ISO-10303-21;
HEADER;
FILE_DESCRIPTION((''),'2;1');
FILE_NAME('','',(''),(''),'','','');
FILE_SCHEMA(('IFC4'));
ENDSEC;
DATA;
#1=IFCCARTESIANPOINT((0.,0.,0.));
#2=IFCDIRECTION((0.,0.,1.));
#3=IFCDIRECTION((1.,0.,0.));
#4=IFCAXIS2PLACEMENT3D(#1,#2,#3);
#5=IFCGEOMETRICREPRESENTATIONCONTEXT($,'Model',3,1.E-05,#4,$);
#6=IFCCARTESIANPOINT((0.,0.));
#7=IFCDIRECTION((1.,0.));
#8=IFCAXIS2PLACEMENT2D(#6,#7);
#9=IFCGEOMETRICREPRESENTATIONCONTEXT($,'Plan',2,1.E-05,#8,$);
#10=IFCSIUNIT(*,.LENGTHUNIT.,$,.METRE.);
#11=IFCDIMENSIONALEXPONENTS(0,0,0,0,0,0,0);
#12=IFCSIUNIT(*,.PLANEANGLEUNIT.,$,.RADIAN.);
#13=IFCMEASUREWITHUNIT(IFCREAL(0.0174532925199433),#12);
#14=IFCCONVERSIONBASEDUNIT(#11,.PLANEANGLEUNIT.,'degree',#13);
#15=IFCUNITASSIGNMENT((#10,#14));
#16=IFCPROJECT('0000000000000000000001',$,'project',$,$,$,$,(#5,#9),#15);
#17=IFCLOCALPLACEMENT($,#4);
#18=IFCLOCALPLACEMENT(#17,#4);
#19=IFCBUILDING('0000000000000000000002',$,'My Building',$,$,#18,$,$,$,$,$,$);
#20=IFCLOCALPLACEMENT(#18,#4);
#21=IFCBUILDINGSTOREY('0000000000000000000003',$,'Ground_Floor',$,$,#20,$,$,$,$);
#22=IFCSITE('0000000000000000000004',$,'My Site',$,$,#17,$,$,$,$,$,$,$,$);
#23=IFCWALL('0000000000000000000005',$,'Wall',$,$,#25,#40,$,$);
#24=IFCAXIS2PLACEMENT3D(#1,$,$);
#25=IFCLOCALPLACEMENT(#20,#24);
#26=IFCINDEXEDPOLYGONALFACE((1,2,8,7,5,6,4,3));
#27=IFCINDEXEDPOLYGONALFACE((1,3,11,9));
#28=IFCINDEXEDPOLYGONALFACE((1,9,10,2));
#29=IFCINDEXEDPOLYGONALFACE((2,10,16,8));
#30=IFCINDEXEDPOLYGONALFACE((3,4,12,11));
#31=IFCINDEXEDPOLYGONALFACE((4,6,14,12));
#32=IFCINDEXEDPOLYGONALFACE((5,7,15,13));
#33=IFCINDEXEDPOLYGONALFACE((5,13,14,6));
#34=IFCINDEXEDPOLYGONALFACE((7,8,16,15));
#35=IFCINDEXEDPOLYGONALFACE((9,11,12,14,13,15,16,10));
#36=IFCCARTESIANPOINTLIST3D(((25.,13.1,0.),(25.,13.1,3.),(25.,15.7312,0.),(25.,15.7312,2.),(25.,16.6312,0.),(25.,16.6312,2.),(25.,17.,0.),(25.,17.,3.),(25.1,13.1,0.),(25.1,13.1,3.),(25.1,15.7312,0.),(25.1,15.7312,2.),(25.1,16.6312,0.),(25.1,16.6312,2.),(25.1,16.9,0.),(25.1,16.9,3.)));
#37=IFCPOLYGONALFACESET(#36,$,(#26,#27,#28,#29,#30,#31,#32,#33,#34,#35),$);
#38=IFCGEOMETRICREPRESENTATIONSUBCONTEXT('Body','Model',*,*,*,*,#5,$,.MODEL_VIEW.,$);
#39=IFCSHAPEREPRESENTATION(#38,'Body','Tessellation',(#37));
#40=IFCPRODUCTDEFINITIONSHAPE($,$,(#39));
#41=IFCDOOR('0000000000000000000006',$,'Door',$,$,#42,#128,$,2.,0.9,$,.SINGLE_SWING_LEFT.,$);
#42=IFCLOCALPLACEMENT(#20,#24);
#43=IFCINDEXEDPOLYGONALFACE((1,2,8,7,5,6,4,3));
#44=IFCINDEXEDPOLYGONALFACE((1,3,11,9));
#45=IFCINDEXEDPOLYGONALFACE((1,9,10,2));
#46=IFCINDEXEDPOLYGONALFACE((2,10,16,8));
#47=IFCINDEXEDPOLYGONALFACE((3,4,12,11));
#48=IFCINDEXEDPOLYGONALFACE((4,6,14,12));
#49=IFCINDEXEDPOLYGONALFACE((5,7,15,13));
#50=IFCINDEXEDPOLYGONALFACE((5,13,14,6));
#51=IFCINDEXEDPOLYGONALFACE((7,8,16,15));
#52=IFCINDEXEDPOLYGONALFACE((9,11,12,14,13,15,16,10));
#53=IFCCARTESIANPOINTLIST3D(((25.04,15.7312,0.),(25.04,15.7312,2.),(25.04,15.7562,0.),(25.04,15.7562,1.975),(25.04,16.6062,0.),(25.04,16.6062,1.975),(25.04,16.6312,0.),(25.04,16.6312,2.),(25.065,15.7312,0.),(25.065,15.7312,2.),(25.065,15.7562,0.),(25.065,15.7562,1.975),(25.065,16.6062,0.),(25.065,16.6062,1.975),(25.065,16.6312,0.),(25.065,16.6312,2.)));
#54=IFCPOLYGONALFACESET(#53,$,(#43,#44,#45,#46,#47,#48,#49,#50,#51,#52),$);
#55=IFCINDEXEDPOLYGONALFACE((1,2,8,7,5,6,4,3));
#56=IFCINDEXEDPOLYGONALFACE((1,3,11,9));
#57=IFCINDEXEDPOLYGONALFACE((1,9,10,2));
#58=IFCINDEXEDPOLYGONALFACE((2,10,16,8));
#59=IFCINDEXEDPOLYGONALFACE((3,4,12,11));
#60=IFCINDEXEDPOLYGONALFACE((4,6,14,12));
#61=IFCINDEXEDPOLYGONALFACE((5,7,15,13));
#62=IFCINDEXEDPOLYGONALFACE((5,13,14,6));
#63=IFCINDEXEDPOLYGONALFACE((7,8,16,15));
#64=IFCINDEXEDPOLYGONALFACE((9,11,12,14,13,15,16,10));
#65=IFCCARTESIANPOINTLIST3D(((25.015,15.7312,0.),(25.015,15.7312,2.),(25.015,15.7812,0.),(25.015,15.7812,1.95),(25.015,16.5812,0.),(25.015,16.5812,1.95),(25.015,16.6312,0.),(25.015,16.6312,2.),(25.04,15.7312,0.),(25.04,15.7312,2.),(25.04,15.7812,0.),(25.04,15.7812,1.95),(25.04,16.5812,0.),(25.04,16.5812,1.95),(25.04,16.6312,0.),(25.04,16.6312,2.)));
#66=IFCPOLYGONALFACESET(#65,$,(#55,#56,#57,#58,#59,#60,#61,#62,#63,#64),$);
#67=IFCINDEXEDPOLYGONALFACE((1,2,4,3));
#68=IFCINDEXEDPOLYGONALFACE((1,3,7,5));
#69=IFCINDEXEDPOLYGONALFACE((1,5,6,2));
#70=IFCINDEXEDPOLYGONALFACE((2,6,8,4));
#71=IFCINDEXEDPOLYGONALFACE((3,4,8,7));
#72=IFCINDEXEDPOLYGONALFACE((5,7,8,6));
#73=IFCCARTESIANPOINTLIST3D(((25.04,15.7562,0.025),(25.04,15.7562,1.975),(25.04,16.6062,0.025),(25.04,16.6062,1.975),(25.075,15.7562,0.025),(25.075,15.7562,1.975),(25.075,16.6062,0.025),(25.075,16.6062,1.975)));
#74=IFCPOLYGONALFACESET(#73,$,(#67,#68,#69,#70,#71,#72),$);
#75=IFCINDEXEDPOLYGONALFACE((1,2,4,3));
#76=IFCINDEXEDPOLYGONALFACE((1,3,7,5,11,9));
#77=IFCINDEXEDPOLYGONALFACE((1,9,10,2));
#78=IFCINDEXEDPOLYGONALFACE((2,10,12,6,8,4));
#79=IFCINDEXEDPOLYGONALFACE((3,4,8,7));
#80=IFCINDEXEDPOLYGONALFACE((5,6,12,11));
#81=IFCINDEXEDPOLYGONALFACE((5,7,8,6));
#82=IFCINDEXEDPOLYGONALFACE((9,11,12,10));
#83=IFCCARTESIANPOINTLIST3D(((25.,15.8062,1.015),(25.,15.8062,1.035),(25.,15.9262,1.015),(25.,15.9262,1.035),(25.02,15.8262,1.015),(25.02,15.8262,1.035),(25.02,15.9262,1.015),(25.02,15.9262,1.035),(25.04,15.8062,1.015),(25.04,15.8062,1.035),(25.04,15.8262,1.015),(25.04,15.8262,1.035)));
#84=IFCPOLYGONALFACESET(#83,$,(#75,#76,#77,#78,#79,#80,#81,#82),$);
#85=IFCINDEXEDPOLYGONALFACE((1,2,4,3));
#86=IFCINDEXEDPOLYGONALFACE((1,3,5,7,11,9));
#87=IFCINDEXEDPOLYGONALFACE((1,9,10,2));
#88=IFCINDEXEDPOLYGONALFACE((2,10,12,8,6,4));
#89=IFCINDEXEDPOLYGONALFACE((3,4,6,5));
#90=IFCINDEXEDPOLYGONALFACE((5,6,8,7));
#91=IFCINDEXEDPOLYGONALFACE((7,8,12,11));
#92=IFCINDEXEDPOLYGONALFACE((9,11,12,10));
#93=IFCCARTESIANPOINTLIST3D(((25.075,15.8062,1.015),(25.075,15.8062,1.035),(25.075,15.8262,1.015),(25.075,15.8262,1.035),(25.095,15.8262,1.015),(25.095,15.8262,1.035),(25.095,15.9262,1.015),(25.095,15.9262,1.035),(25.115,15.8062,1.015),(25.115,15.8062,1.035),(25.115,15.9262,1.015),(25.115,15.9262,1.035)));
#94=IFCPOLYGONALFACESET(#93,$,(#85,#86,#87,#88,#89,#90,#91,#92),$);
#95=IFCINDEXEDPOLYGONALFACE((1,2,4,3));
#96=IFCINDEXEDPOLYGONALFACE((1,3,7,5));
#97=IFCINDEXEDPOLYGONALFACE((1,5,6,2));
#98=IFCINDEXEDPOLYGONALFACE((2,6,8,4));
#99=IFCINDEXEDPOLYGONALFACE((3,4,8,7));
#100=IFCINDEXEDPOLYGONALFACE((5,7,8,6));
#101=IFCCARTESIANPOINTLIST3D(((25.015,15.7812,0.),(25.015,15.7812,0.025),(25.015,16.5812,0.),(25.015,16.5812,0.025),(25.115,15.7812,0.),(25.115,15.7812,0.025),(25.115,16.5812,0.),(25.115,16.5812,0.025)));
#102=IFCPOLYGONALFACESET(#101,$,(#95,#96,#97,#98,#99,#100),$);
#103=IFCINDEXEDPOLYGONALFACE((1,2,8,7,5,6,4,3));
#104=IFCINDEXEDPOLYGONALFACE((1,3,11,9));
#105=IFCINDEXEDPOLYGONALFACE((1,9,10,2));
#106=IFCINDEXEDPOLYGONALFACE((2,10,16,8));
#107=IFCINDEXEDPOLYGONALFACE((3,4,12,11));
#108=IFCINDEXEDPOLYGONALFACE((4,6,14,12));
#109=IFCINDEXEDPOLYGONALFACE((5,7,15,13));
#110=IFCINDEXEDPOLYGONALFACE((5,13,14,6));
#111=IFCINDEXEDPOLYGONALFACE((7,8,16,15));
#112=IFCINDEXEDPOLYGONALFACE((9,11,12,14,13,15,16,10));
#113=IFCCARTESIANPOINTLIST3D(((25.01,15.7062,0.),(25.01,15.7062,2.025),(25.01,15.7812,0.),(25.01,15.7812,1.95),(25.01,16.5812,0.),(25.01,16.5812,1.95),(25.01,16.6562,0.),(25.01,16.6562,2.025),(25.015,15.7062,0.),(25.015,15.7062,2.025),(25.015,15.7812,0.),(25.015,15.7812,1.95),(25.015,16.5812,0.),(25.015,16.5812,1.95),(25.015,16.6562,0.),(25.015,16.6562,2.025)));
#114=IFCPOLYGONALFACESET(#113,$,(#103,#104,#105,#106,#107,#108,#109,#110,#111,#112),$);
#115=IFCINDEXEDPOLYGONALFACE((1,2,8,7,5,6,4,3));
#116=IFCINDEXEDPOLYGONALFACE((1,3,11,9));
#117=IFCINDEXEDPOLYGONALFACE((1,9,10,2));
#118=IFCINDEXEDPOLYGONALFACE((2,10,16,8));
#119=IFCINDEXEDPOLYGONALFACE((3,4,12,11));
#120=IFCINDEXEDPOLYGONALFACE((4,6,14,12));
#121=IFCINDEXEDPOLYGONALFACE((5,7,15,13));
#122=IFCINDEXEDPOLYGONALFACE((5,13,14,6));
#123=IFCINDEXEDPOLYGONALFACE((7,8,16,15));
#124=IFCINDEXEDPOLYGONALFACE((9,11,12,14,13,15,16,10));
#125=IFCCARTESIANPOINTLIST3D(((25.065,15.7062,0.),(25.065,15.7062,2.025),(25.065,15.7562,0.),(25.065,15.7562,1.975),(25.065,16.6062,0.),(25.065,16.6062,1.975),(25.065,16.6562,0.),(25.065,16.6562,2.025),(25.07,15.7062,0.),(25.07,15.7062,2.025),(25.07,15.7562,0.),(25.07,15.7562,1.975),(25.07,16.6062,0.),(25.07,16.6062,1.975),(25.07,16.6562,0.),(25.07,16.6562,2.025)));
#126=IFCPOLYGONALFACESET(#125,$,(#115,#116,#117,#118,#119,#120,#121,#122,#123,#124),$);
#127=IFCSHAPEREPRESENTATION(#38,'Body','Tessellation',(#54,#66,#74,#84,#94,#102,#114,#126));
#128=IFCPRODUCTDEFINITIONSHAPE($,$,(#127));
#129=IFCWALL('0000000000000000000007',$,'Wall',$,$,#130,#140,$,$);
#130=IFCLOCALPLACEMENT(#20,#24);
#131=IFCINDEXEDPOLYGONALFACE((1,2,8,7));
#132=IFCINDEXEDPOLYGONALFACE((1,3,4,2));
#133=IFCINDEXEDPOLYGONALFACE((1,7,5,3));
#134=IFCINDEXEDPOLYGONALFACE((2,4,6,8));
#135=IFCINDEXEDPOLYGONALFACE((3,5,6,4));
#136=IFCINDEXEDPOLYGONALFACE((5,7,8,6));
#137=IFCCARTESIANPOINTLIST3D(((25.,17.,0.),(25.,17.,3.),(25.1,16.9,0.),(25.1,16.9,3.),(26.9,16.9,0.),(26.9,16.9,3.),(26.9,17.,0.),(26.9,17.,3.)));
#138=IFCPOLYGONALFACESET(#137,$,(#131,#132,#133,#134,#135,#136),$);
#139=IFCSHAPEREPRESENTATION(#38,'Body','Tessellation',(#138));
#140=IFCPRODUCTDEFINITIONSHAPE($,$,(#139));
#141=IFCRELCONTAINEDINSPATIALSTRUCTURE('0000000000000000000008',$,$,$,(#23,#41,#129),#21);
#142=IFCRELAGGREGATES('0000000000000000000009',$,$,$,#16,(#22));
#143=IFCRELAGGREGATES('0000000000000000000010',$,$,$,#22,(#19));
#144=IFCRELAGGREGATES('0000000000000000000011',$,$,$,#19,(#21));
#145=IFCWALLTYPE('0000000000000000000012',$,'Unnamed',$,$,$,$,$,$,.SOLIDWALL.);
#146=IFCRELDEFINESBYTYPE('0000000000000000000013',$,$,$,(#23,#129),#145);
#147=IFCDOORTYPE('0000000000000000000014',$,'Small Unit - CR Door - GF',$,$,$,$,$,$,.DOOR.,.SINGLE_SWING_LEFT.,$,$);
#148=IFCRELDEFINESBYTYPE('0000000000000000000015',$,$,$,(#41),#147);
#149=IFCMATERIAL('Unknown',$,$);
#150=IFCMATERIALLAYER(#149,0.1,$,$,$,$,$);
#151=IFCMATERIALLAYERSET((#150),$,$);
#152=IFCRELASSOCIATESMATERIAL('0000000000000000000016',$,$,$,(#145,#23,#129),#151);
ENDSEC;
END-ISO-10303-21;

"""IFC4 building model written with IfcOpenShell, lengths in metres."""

from ifc_helpers import new_model, entity, si_unit, converted_unit, frame, origin_with_axes, origin_2d_with_axis, place, context, subcontext, project, spatial, line, indexed_curve, outline, extrude, shape, source, transform, mapped, material, layer, layer_set, layer_usage, type_object, type_shapes, element, fill, save


model = new_model("IFC4")

# Units and contexts
model_context = context("Model", 3, precision=1e-05, world=origin_with_axes())
plan_context = context("Plan", 2, precision=1e-05, world=origin_2d_with_axis())
body_context_1 = subcontext(model_context, "Body", "Model", "MODEL_VIEW")
body_context_2 = subcontext(plan_context, "Body", "Plan", "PLAN_VIEW")
ifc_project = project(units=[si_unit("LENGTHUNIT", "METRE"), converted_unit("PLANEANGLEUNIT", "degree", entity("IfcReal", 0.0174532925199433), si_unit("PLANEANGLEUNIT", "RADIAN"), dimensions=[0, 0, 0, 0, 0, 0, 0])], contexts=[model_context, plan_context])

# Site, building, storey
site_placement = place(None, origin_with_axes())
site = spatial("IfcSite", under=ifc_project, at=site_placement, Name="My Site")
building_placement = place(site_placement, origin_with_axes())
building = spatial("IfcBuilding", under=site, at=building_placement, Name="My Building")
storey_placement = place(building_placement, origin_with_axes())
storey = spatial("IfcBuildingStorey", under=building, at=storey_placement, Name="Ground_Floor")

# Shared definitions
ifc_material = material(Name="Unknown")
ifc_layer = layer(ifc_material, 0.1)
ifc_layer_set = layer_set([ifc_layer])
wall_type = type_object("IfcWallType", Name="Unnamed", PredefinedType="SOLIDWALL", material=ifc_layer_set)

# Shared definitions
shared_shape_1 = source(origin_with_axes(), body_context_1, "Body", "SweptSolid", [
    extrude(outline(indexed_curve([(0.0, 0.0), (0.9, 0.0), (0.9, 2.0), (0.0, 2.0)], segments=[line(1, 2, 3, 4, 1)])), frame((0.0, -0.6, 0.0), z_axis=(0.0, -1.0, 0.0), x_axis=(1.0, 0.0, 0.0)), (0.0, 0.0, -1.0), 1.2),
])
door_type_1 = type_object("IfcDoorType", Name="Small Unit - CR Door - GF", OperationType="SINGLE_SWING_LEFT", PredefinedType="DOOR")
shared_shape_2 = source(origin_with_axes(), body_context_1, "Body", "SweptSolid", [
    extrude(outline(indexed_curve([(0.0, 0.0), (0.0, 2.0), (0.9, 2.0), (0.9, 0.0), (0.875, 0.0), (0.875, 1.975), (0.025, 1.975), (0.025, 0.0)], segments=[line(1, 2, 3, 4, 5, 6, 7, 8, 1)])), frame((0.0, 0.025, 0.0), z_axis=(0.0, -1.0, 0.0), x_axis=(1.0, 0.0, 0.0)), (0.0, 0.0, -1.0), 0.025),
    extrude(outline(indexed_curve([(0.0, 0.0), (0.0, 2.0), (0.9, 2.0), (0.9, 0.0), (0.85, 0.0), (0.85, 1.95), (0.05, 1.95), (0.05, 0.0)], segments=[line(1, 2, 3, 4, 5, 6, 7, 8, 1)])), frame((0.0, 0.0, 0.0), z_axis=(0.0, -1.0, 0.0), x_axis=(1.0, 0.0, 0.0)), (0.0, 0.0, -1.0), 0.025),
    extrude(outline(indexed_curve([(0.0, 0.0), (0.85, 0.0), (0.85, 0.035), (0.0, 0.035)], segments=[line(1, 2, 3, 4, 1)])), frame((0.025, 0.025, 0.025), z_axis=(0.0, 0.0, 1.0), x_axis=(1.0, 0.0, 0.0)), (0.0, 0.0, 1.0), 1.95),
    extrude(outline(indexed_curve([(0.0, 0.0), (0.0, -0.04), (-0.12, -0.04), (-0.12, -0.02), (-0.02, -0.02), (-0.02, 0.0)], segments=[line(1, 2, 3, 4, 5, 6, 1)])), frame((0.825, 0.025, 1.015), z_axis=(0.0, 0.0, 1.0), x_axis=(1.0, 0.0, 0.0)), (0.0, 0.0, 1.0), 0.02),
    extrude(outline(indexed_curve([(0.0, 0.0), (0.0, 0.04), (-0.12, 0.04), (-0.12, 0.02), (-0.02, 0.02), (-0.02, 0.0)], segments=[line(1, 2, 3, 4, 5, 6, 1)])), frame((0.825, 0.06, 1.015), z_axis=(0.0, 0.0, 1.0), x_axis=(1.0, 0.0, 0.0)), (0.0, 0.0, 1.0), 0.02),
    extrude(outline(indexed_curve([(0.0, 0.0), (0.8, 0.0), (0.8, 0.1), (0.0, 0.1)], segments=[line(1, 2, 3, 4, 1)])), frame((0.05, 0.0, 0.0), z_axis=(0.0, 0.0, 1.0), x_axis=(1.0, 0.0, 0.0)), (0.0, 0.0, 1.0), 0.025),
    extrude(outline(indexed_curve([(0.0, 0.0), (0.0, 2.025), (0.95, 2.025), (0.95, 0.0), (0.875, 0.0), (0.875, 1.95), (0.075, 1.95), (0.075, 0.0)], segments=[line(1, 2, 3, 4, 5, 6, 7, 8, 1)])), frame((-0.025, -0.005, 0.0), z_axis=(0.0, -1.0, 0.0), x_axis=(1.0, 0.0, 0.0)), (0.0, 0.0, -1.0), 0.005),
    extrude(outline(indexed_curve([(0.0, 0.0), (0.0, 2.025), (0.95, 2.025), (0.95, 0.0), (0.9, 0.0), (0.9, 1.975), (0.05, 1.975), (0.05, 0.0)], segments=[line(1, 2, 3, 4, 5, 6, 7, 8, 1)])), frame((-0.025, 0.05, 0.0), z_axis=(0.0, -1.0, 0.0), x_axis=(1.0, 0.0, 0.0)), (0.0, 0.0, -1.0), 0.005),
])
shared_shape_3 = source(origin_with_axes(), body_context_2, "Body", "Curve2D", [
    entity("IfcIndexedPolyCurve", entity("IfcCartesianPointList2D", [[0.0, 0.0], [0.0, 0.05], [0.025, 0.05], [0.025, 0.025], [0.05, 0.025], [0.05, 0.0]]), [entity("IfcLineIndex", [1, 2, 3, 4, 5, 6, 1])]),
    entity("IfcIndexedPolyCurve", entity("IfcCartesianPointList2D", [[0.9, 0.0], [0.9, 0.05], [0.875, 0.05], [0.875, 0.025], [0.85, 0.025], [0.85, 0.0]]), [entity("IfcLineIndex", [1, 2, 3, 4, 5, 6, 1])]),
    entity("IfcTrimmedCurve", entity("IfcEllipse", entity("IfcAxis2Placement2D", entity("IfcCartesianPoint", [0.06, 0.05]), entity("IfcDirection", [1.0, 0.0])), 0.815, 0.85), [entity("IfcCartesianPoint", [0.875, 0.05])], [entity("IfcCartesianPoint", [0.06, 0.9])], True, "CARTESIAN"),
    entity("IfcIndexedPolyCurve", entity("IfcCartesianPointList2D", [[0.025, 0.05], [0.06, 0.05], [0.06, 0.9], [0.025, 0.9]]), [entity("IfcLineIndex", [1, 2, 3, 4, 1])]),
])
type_shapes(door_type_1, [shared_shape_2, shared_shape_3])

# Wall, opening, door
ifc_layer_usage_1 = layer_usage(ifc_layer_set, "AXIS2", "POSITIVE", 0.0)
wall_1_placement = place(storey_placement, frame((25.0, 17.0, 0.0), z_axis=(0.0, 0.0, 1.0), x_axis=(0.0, -1.0, 0.0)))
wall_1 = element("IfcWall", 1, at=wall_1_placement, inside=storey, type_object=wall_type, material=ifc_layer_usage_1, Name="Wall", context=body_context_1, shape_type="SweptSolid", body=[
    extrude(outline(indexed_curve([(0.0, 0.0), (0.1, 0.1), (3.9, 0.1), (3.9, 0.0)], segments=[line(1, 2, 3, 4, 1)])), origin_with_axes(), (0.0, 0.0, 1.0), 3.0),
])
opening_1_placement = place(wall_1_placement, frame((0.3688, 0.015, 0.0), z_axis=(0.0, 0.0, 1.0), x_axis=(1.0, 0.0, 0.0)))
opening_1 = element("IfcOpeningElement", 2, at=opening_1_placement, cuts=wall_1, PredefinedType="OPENING", context=body_context_1, shape_type="MappedRepresentation", body=[
    mapped(shared_shape_1, transform((0.0, 0.0, 0.0), x_axis=(1.0, 0.0, 0.0), y_axis=(0.0, 1.0, 0.0), z_axis=(0.0, 0.0, 1.0), scale=1.0)),
])
door_1_placement = place(opening_1_placement, frame((0.0, 0.0, 0.0), z_axis=(0.0, 0.0, 1.0), x_axis=(1.0, 0.0, 0.0)))
door_1 = element("IfcDoor", 3, at=door_1_placement, inside=storey, type_object=door_type_1, Name="Door", OperationType="SINGLE_SWING_LEFT", OverallHeight=2.0, OverallWidth=0.9, shapes=[
    shape(body_context_1, "Body", "MappedRepresentation", [mapped(shared_shape_2, transform((0.0, 0.0, 0.0), x_axis=(1.0, 0.0, 0.0), y_axis=(0.0, 1.0, 0.0), z_axis=(0.0, 0.0, 1.0), scale=1.0))]),
    shape(body_context_2, "Body", "MappedRepresentation", [mapped(shared_shape_3, transform((0.0, 0.0, 0.0), x_axis=(1.0, 0.0, 0.0), y_axis=(0.0, 1.0, 0.0), z_axis=(0.0, 0.0, 1.0), scale=1.0))]),
])
fill(opening_1, door_1)

# Wall
ifc_layer_usage_2 = layer_usage(ifc_layer_set, "AXIS2", "POSITIVE", 0.0)
wall_2_placement = place(storey_placement, frame((27.0, 17.0, 0.0), z_axis=(0.0, 0.0, 1.0), x_axis=(-1.0, 0.0, 0.0)))
element("IfcWall", 4, at=wall_2_placement, inside=storey, type_object=wall_type, material=ifc_layer_usage_2, Name="Wall", context=body_context_1, shape_type="SweptSolid", body=[
    extrude(outline(indexed_curve([(0.1, 0.0), (0.1, 0.1), (1.9, 0.1), (2.0, 0.0)], segments=[line(1, 2, 3, 4, 1)])), origin_with_axes(), (0.0, 0.0, 1.0), 3.0),
])

save(model, "model.ifc")
